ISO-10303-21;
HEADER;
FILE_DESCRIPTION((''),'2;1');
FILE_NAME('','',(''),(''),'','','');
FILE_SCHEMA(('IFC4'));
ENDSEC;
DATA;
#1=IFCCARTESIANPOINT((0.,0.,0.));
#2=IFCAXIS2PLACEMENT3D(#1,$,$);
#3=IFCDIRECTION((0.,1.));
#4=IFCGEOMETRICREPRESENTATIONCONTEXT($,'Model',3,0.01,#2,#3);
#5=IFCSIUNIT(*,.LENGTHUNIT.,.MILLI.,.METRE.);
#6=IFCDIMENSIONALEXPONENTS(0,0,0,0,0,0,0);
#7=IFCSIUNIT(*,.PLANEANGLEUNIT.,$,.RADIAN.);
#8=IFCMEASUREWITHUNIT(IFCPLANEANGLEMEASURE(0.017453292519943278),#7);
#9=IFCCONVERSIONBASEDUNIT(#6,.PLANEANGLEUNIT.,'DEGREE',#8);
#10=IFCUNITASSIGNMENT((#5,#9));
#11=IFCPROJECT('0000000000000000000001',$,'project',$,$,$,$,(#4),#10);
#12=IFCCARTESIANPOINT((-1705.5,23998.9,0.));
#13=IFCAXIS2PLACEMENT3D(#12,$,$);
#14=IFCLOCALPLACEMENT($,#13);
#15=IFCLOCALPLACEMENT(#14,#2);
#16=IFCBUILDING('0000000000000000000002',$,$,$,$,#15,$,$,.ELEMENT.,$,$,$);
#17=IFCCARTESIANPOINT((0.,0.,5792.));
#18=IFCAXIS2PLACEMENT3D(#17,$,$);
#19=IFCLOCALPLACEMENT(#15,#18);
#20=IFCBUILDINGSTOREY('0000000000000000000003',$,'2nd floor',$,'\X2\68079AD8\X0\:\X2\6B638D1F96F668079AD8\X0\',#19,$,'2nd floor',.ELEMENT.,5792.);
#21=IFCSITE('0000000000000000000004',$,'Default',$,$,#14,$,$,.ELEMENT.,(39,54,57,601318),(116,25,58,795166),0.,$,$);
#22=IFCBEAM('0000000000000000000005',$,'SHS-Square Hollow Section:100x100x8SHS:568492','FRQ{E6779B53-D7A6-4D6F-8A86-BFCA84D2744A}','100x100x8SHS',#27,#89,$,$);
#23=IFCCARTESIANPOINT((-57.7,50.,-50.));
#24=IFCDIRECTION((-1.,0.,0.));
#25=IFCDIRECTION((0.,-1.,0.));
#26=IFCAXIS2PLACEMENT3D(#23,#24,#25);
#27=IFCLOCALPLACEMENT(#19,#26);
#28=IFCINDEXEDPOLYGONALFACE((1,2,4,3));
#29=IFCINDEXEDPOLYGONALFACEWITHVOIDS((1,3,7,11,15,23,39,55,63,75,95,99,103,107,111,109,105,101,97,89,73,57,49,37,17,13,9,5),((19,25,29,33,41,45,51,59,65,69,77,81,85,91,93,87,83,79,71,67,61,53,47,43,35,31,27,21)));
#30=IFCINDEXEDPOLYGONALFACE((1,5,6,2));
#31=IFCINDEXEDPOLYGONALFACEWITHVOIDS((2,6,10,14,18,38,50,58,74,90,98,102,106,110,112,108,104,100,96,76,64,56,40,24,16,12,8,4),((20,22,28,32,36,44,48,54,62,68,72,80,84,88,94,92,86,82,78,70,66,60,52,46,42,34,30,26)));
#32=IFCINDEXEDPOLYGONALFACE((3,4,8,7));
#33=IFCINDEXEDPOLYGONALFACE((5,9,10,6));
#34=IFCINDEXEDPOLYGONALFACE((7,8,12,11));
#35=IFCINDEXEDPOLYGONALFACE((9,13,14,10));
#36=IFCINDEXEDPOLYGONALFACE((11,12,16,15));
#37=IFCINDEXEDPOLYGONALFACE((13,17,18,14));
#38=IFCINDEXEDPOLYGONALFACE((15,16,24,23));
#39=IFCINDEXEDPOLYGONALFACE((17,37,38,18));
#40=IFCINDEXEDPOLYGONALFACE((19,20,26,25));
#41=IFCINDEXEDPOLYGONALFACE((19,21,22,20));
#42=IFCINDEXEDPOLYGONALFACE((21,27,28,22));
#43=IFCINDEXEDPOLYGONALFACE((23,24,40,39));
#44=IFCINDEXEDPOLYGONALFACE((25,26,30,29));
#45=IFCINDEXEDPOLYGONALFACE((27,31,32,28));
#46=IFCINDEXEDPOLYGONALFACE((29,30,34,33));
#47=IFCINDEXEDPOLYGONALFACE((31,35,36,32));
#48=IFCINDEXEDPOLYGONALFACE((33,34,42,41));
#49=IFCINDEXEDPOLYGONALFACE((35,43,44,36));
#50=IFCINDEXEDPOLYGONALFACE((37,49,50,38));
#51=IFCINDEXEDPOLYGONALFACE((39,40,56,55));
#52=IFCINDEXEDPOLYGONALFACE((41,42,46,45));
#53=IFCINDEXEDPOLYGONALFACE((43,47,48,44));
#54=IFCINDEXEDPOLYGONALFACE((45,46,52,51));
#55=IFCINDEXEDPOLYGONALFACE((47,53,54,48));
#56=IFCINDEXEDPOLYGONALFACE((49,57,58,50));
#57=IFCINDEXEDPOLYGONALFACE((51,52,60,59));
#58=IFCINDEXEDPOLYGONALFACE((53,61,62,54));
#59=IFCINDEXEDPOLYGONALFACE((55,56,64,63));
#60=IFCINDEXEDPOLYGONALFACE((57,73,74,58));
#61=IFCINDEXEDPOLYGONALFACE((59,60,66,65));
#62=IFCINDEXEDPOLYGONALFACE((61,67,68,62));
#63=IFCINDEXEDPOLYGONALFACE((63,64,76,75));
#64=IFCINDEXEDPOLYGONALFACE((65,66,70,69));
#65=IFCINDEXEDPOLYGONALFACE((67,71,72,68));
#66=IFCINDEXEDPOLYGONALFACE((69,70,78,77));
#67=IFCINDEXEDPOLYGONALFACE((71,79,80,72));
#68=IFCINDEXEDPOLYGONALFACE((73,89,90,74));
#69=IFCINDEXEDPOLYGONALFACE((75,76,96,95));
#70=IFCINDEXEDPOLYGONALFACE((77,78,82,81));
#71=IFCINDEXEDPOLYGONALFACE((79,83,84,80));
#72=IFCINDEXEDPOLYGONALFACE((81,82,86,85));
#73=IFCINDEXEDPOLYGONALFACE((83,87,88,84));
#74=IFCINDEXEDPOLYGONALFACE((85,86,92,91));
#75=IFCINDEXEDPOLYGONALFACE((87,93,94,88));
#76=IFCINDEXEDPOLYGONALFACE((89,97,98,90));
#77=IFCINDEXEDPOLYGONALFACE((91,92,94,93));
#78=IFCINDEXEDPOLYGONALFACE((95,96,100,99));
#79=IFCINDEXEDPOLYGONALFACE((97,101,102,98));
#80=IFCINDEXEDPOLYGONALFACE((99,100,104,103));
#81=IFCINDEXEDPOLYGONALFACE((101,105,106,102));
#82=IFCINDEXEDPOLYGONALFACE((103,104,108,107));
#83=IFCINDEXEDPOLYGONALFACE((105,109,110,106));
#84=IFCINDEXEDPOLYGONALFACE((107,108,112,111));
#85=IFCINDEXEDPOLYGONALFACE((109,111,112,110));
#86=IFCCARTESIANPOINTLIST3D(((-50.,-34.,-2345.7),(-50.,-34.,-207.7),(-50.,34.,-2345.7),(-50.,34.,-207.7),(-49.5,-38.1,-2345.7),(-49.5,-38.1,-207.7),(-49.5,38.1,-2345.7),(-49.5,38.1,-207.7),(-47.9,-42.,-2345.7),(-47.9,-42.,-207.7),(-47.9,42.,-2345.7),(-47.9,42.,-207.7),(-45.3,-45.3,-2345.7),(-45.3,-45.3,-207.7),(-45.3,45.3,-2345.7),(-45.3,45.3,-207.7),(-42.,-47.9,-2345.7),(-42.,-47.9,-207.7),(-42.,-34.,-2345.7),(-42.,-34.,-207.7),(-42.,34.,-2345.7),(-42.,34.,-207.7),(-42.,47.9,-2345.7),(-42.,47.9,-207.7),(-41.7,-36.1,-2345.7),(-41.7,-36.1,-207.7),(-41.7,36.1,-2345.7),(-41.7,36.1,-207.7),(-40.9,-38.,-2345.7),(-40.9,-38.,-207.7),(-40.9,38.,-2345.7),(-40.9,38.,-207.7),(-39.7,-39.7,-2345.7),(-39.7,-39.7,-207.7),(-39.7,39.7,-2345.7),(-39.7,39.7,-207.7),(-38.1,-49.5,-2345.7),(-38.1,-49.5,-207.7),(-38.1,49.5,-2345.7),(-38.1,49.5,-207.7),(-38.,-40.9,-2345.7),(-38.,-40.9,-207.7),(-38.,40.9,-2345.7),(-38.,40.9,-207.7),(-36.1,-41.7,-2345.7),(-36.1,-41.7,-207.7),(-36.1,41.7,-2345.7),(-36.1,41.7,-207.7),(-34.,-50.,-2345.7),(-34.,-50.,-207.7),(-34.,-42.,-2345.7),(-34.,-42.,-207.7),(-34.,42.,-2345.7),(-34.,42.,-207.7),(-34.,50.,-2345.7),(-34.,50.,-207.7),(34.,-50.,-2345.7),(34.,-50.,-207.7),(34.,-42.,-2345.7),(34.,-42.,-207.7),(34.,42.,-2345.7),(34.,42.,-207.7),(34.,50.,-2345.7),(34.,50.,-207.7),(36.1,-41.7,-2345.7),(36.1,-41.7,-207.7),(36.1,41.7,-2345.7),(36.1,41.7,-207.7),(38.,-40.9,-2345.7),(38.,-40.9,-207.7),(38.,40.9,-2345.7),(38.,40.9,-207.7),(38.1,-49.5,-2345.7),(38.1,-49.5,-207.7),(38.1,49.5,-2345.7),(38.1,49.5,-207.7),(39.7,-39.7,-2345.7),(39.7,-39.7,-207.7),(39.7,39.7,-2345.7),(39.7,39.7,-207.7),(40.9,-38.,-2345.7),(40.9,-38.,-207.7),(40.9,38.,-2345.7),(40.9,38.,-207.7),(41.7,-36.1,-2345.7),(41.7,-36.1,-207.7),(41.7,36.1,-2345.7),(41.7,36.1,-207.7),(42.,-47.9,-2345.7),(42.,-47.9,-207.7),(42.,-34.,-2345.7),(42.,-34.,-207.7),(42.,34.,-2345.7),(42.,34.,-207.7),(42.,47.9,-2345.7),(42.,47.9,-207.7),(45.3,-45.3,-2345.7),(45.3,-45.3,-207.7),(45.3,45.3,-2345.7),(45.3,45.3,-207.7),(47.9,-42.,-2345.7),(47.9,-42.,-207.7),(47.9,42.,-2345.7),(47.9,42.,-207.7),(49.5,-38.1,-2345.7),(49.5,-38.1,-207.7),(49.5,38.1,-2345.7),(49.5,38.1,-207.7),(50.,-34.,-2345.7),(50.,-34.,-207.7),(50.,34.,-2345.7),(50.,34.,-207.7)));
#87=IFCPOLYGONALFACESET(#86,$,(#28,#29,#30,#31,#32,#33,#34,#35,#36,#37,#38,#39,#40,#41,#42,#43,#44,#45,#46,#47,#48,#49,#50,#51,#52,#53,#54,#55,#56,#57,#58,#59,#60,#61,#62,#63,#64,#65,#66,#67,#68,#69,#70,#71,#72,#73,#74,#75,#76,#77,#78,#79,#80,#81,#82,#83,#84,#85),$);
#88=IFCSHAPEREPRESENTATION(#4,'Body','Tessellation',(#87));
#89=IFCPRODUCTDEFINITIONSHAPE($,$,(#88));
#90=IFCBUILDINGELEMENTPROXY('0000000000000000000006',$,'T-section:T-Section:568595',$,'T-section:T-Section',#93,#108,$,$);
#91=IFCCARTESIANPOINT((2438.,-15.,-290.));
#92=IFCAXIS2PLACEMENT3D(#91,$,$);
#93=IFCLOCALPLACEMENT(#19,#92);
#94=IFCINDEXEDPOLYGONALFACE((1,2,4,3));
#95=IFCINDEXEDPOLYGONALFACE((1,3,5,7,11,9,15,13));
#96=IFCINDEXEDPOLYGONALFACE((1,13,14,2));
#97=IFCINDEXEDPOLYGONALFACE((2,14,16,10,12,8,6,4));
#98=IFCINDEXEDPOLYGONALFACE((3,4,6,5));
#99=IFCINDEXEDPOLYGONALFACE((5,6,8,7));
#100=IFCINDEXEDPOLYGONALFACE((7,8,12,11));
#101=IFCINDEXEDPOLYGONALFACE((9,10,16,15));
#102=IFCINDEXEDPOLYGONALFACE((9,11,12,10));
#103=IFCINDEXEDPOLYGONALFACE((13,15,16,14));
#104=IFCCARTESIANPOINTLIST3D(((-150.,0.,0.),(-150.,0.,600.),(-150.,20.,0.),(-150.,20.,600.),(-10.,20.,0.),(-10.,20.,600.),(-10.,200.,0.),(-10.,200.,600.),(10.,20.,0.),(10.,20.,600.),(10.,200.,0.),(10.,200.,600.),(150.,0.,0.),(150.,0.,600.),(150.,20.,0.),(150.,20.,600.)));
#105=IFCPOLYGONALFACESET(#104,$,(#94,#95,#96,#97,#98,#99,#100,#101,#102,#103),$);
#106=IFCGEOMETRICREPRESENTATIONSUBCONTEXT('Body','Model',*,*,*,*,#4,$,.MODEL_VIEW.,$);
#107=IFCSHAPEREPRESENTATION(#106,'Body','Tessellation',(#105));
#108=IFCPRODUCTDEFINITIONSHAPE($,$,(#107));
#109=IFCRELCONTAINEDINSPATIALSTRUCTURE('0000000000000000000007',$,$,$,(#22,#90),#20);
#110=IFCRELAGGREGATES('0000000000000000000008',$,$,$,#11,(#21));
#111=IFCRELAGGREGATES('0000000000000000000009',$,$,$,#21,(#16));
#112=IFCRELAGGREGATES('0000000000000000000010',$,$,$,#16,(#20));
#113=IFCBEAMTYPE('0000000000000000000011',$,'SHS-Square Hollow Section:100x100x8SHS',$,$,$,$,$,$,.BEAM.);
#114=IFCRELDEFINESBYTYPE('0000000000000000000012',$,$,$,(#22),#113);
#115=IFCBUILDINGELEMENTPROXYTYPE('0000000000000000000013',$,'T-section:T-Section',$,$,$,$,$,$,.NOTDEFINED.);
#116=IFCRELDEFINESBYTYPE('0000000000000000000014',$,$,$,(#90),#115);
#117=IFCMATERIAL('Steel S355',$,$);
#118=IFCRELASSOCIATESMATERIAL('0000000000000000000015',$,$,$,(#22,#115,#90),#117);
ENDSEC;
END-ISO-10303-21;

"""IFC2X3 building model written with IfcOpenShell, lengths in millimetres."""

from ifc_helpers import new_model, entity, si_unit, converted_unit, direction, frame, origin, origin_2d, place, context, subcontext, project, spatial, polyline, hollow_rectangle, outline, extrude, clip, halfspace, source, transform, mapped, material, type_object, type_shapes, element, save


model = new_model("IFC2X3")

# Units and contexts
model_context = context("Model", 3, precision=0.01, world=origin(), true_north=direction((0.0, 1.0)))
body_context = subcontext(model_context, "Body", "Model", "MODEL_VIEW")
ifc_project = project(units=[si_unit("LENGTHUNIT", "METRE", prefix="MILLI"), converted_unit("PLANEANGLEUNIT", "DEGREE", entity("IfcPlaneAngleMeasure", 0.017453292519943278), si_unit("PLANEANGLEUNIT", "RADIAN"), dimensions=[0, 0, 0, 0, 0, 0, 0])], contexts=[model_context])

# Site, building, storey
site_placement = place(None, frame((-1705.5, 23998.9, 0.0)))
site = spatial("IfcSite", under=ifc_project, at=site_placement, Name="Default", CompositionType="ELEMENT", RefLatitude=(39, 54, 57, 601318), RefLongitude=(116, 25, 58, 795166), RefElevation=0.0)
building_placement = place(site_placement, origin())
building = spatial("IfcBuilding", under=site, at=building_placement, CompositionType="ELEMENT")
storey_placement = place(building_placement, frame((0.0, 0.0, 5792.0)))
storey = spatial("IfcBuildingStorey", under=building, at=storey_placement, Name="2nd floor", ObjectType="标高:正负零标高", LongName="2nd floor", CompositionType="ELEMENT", Elevation=5792.0)

# Beam
ifc_material_1 = material(Name="Steel S355")
beam_type_1 = type_object("IfcBeamType", Name="SHS-Square Hollow Section:100x100x8SHS", PredefinedType="BEAM")
beam_1_placement = place(storey_placement, frame((-57.7, 50.0, -50.0), z_axis=(-1.0, 0.0, 0.0), x_axis=(0.0, -1.0, 0.0)))
element("IfcBeam", 1, at=beam_1_placement, inside=storey, type_object=beam_type_1, material=ifc_material_1, Name="SHS-Square Hollow Section:100x100x8SHS:568492", Description="FRQ{E6779B53-D7A6-4D6F-8A86-BFCA84D2744A}", ObjectType="100x100x8SHS", context=model_context, shape_type="Clipping", body=[
    clip(clip(extrude(hollow_rectangle(XDim=100.0, YDim=100.0, WallThickness=8.0, InnerFilletRadius=8.0, OuterFilletRadius=16.0, at=origin_2d()), origin(), (0.0, 0.0, -1.0), 2551.4), halfspace(frame((50.0, -5742.0, -2345.7), z_axis=(0.0, 0.0, 1.0), x_axis=(1.0, 0.0, 0.0)), True)), halfspace(frame((50.0, -5742.0, -207.7), z_axis=(0.0, 0.0, -1.0), x_axis=(-1.0, 0.0, 0.0)), True)),
])

# Building element proxy
building_element_proxy_type_1 = type_object("IfcBuildingElementProxyType", Name="T-section:T-Section", PredefinedType="NOTDEFINED", material=ifc_material_1)
shared_shape_1 = source(origin(), body_context, "Body", "SweptSolid", [
    extrude(outline(polyline([(-140.0, 10.0), (-140.0, -10.0), (40.0, -10.0), (40.0, -150.0), (60.0, -150.0), (60.0, 150.0), (40.0, 150.0), (40.0, 10.0), (-140.0, 10.0)])), frame((0.0, 60.0, 0.0), z_axis=(0.0, 0.0, -1.0), x_axis=(0.0, -1.0, 0.0)), (0.0, 0.0, -1.0), 600.0),
])
type_shapes(building_element_proxy_type_1, [shared_shape_1])
proxy_1_placement = place(storey_placement, frame((2438.0, -15.0, -290.0)))
element("IfcBuildingElementProxy", 2, at=proxy_1_placement, inside=storey, type_object=building_element_proxy_type_1, material=ifc_material_1, Name="T-section:T-Section:568595", ObjectType="T-section:T-Section", context=body_context, shape_type="MappedRepresentation", body=[
    mapped(shared_shape_1, transform((0.0, 0.0, 0.0), scale=1.0)),
])

save(model, "model.ifc")
